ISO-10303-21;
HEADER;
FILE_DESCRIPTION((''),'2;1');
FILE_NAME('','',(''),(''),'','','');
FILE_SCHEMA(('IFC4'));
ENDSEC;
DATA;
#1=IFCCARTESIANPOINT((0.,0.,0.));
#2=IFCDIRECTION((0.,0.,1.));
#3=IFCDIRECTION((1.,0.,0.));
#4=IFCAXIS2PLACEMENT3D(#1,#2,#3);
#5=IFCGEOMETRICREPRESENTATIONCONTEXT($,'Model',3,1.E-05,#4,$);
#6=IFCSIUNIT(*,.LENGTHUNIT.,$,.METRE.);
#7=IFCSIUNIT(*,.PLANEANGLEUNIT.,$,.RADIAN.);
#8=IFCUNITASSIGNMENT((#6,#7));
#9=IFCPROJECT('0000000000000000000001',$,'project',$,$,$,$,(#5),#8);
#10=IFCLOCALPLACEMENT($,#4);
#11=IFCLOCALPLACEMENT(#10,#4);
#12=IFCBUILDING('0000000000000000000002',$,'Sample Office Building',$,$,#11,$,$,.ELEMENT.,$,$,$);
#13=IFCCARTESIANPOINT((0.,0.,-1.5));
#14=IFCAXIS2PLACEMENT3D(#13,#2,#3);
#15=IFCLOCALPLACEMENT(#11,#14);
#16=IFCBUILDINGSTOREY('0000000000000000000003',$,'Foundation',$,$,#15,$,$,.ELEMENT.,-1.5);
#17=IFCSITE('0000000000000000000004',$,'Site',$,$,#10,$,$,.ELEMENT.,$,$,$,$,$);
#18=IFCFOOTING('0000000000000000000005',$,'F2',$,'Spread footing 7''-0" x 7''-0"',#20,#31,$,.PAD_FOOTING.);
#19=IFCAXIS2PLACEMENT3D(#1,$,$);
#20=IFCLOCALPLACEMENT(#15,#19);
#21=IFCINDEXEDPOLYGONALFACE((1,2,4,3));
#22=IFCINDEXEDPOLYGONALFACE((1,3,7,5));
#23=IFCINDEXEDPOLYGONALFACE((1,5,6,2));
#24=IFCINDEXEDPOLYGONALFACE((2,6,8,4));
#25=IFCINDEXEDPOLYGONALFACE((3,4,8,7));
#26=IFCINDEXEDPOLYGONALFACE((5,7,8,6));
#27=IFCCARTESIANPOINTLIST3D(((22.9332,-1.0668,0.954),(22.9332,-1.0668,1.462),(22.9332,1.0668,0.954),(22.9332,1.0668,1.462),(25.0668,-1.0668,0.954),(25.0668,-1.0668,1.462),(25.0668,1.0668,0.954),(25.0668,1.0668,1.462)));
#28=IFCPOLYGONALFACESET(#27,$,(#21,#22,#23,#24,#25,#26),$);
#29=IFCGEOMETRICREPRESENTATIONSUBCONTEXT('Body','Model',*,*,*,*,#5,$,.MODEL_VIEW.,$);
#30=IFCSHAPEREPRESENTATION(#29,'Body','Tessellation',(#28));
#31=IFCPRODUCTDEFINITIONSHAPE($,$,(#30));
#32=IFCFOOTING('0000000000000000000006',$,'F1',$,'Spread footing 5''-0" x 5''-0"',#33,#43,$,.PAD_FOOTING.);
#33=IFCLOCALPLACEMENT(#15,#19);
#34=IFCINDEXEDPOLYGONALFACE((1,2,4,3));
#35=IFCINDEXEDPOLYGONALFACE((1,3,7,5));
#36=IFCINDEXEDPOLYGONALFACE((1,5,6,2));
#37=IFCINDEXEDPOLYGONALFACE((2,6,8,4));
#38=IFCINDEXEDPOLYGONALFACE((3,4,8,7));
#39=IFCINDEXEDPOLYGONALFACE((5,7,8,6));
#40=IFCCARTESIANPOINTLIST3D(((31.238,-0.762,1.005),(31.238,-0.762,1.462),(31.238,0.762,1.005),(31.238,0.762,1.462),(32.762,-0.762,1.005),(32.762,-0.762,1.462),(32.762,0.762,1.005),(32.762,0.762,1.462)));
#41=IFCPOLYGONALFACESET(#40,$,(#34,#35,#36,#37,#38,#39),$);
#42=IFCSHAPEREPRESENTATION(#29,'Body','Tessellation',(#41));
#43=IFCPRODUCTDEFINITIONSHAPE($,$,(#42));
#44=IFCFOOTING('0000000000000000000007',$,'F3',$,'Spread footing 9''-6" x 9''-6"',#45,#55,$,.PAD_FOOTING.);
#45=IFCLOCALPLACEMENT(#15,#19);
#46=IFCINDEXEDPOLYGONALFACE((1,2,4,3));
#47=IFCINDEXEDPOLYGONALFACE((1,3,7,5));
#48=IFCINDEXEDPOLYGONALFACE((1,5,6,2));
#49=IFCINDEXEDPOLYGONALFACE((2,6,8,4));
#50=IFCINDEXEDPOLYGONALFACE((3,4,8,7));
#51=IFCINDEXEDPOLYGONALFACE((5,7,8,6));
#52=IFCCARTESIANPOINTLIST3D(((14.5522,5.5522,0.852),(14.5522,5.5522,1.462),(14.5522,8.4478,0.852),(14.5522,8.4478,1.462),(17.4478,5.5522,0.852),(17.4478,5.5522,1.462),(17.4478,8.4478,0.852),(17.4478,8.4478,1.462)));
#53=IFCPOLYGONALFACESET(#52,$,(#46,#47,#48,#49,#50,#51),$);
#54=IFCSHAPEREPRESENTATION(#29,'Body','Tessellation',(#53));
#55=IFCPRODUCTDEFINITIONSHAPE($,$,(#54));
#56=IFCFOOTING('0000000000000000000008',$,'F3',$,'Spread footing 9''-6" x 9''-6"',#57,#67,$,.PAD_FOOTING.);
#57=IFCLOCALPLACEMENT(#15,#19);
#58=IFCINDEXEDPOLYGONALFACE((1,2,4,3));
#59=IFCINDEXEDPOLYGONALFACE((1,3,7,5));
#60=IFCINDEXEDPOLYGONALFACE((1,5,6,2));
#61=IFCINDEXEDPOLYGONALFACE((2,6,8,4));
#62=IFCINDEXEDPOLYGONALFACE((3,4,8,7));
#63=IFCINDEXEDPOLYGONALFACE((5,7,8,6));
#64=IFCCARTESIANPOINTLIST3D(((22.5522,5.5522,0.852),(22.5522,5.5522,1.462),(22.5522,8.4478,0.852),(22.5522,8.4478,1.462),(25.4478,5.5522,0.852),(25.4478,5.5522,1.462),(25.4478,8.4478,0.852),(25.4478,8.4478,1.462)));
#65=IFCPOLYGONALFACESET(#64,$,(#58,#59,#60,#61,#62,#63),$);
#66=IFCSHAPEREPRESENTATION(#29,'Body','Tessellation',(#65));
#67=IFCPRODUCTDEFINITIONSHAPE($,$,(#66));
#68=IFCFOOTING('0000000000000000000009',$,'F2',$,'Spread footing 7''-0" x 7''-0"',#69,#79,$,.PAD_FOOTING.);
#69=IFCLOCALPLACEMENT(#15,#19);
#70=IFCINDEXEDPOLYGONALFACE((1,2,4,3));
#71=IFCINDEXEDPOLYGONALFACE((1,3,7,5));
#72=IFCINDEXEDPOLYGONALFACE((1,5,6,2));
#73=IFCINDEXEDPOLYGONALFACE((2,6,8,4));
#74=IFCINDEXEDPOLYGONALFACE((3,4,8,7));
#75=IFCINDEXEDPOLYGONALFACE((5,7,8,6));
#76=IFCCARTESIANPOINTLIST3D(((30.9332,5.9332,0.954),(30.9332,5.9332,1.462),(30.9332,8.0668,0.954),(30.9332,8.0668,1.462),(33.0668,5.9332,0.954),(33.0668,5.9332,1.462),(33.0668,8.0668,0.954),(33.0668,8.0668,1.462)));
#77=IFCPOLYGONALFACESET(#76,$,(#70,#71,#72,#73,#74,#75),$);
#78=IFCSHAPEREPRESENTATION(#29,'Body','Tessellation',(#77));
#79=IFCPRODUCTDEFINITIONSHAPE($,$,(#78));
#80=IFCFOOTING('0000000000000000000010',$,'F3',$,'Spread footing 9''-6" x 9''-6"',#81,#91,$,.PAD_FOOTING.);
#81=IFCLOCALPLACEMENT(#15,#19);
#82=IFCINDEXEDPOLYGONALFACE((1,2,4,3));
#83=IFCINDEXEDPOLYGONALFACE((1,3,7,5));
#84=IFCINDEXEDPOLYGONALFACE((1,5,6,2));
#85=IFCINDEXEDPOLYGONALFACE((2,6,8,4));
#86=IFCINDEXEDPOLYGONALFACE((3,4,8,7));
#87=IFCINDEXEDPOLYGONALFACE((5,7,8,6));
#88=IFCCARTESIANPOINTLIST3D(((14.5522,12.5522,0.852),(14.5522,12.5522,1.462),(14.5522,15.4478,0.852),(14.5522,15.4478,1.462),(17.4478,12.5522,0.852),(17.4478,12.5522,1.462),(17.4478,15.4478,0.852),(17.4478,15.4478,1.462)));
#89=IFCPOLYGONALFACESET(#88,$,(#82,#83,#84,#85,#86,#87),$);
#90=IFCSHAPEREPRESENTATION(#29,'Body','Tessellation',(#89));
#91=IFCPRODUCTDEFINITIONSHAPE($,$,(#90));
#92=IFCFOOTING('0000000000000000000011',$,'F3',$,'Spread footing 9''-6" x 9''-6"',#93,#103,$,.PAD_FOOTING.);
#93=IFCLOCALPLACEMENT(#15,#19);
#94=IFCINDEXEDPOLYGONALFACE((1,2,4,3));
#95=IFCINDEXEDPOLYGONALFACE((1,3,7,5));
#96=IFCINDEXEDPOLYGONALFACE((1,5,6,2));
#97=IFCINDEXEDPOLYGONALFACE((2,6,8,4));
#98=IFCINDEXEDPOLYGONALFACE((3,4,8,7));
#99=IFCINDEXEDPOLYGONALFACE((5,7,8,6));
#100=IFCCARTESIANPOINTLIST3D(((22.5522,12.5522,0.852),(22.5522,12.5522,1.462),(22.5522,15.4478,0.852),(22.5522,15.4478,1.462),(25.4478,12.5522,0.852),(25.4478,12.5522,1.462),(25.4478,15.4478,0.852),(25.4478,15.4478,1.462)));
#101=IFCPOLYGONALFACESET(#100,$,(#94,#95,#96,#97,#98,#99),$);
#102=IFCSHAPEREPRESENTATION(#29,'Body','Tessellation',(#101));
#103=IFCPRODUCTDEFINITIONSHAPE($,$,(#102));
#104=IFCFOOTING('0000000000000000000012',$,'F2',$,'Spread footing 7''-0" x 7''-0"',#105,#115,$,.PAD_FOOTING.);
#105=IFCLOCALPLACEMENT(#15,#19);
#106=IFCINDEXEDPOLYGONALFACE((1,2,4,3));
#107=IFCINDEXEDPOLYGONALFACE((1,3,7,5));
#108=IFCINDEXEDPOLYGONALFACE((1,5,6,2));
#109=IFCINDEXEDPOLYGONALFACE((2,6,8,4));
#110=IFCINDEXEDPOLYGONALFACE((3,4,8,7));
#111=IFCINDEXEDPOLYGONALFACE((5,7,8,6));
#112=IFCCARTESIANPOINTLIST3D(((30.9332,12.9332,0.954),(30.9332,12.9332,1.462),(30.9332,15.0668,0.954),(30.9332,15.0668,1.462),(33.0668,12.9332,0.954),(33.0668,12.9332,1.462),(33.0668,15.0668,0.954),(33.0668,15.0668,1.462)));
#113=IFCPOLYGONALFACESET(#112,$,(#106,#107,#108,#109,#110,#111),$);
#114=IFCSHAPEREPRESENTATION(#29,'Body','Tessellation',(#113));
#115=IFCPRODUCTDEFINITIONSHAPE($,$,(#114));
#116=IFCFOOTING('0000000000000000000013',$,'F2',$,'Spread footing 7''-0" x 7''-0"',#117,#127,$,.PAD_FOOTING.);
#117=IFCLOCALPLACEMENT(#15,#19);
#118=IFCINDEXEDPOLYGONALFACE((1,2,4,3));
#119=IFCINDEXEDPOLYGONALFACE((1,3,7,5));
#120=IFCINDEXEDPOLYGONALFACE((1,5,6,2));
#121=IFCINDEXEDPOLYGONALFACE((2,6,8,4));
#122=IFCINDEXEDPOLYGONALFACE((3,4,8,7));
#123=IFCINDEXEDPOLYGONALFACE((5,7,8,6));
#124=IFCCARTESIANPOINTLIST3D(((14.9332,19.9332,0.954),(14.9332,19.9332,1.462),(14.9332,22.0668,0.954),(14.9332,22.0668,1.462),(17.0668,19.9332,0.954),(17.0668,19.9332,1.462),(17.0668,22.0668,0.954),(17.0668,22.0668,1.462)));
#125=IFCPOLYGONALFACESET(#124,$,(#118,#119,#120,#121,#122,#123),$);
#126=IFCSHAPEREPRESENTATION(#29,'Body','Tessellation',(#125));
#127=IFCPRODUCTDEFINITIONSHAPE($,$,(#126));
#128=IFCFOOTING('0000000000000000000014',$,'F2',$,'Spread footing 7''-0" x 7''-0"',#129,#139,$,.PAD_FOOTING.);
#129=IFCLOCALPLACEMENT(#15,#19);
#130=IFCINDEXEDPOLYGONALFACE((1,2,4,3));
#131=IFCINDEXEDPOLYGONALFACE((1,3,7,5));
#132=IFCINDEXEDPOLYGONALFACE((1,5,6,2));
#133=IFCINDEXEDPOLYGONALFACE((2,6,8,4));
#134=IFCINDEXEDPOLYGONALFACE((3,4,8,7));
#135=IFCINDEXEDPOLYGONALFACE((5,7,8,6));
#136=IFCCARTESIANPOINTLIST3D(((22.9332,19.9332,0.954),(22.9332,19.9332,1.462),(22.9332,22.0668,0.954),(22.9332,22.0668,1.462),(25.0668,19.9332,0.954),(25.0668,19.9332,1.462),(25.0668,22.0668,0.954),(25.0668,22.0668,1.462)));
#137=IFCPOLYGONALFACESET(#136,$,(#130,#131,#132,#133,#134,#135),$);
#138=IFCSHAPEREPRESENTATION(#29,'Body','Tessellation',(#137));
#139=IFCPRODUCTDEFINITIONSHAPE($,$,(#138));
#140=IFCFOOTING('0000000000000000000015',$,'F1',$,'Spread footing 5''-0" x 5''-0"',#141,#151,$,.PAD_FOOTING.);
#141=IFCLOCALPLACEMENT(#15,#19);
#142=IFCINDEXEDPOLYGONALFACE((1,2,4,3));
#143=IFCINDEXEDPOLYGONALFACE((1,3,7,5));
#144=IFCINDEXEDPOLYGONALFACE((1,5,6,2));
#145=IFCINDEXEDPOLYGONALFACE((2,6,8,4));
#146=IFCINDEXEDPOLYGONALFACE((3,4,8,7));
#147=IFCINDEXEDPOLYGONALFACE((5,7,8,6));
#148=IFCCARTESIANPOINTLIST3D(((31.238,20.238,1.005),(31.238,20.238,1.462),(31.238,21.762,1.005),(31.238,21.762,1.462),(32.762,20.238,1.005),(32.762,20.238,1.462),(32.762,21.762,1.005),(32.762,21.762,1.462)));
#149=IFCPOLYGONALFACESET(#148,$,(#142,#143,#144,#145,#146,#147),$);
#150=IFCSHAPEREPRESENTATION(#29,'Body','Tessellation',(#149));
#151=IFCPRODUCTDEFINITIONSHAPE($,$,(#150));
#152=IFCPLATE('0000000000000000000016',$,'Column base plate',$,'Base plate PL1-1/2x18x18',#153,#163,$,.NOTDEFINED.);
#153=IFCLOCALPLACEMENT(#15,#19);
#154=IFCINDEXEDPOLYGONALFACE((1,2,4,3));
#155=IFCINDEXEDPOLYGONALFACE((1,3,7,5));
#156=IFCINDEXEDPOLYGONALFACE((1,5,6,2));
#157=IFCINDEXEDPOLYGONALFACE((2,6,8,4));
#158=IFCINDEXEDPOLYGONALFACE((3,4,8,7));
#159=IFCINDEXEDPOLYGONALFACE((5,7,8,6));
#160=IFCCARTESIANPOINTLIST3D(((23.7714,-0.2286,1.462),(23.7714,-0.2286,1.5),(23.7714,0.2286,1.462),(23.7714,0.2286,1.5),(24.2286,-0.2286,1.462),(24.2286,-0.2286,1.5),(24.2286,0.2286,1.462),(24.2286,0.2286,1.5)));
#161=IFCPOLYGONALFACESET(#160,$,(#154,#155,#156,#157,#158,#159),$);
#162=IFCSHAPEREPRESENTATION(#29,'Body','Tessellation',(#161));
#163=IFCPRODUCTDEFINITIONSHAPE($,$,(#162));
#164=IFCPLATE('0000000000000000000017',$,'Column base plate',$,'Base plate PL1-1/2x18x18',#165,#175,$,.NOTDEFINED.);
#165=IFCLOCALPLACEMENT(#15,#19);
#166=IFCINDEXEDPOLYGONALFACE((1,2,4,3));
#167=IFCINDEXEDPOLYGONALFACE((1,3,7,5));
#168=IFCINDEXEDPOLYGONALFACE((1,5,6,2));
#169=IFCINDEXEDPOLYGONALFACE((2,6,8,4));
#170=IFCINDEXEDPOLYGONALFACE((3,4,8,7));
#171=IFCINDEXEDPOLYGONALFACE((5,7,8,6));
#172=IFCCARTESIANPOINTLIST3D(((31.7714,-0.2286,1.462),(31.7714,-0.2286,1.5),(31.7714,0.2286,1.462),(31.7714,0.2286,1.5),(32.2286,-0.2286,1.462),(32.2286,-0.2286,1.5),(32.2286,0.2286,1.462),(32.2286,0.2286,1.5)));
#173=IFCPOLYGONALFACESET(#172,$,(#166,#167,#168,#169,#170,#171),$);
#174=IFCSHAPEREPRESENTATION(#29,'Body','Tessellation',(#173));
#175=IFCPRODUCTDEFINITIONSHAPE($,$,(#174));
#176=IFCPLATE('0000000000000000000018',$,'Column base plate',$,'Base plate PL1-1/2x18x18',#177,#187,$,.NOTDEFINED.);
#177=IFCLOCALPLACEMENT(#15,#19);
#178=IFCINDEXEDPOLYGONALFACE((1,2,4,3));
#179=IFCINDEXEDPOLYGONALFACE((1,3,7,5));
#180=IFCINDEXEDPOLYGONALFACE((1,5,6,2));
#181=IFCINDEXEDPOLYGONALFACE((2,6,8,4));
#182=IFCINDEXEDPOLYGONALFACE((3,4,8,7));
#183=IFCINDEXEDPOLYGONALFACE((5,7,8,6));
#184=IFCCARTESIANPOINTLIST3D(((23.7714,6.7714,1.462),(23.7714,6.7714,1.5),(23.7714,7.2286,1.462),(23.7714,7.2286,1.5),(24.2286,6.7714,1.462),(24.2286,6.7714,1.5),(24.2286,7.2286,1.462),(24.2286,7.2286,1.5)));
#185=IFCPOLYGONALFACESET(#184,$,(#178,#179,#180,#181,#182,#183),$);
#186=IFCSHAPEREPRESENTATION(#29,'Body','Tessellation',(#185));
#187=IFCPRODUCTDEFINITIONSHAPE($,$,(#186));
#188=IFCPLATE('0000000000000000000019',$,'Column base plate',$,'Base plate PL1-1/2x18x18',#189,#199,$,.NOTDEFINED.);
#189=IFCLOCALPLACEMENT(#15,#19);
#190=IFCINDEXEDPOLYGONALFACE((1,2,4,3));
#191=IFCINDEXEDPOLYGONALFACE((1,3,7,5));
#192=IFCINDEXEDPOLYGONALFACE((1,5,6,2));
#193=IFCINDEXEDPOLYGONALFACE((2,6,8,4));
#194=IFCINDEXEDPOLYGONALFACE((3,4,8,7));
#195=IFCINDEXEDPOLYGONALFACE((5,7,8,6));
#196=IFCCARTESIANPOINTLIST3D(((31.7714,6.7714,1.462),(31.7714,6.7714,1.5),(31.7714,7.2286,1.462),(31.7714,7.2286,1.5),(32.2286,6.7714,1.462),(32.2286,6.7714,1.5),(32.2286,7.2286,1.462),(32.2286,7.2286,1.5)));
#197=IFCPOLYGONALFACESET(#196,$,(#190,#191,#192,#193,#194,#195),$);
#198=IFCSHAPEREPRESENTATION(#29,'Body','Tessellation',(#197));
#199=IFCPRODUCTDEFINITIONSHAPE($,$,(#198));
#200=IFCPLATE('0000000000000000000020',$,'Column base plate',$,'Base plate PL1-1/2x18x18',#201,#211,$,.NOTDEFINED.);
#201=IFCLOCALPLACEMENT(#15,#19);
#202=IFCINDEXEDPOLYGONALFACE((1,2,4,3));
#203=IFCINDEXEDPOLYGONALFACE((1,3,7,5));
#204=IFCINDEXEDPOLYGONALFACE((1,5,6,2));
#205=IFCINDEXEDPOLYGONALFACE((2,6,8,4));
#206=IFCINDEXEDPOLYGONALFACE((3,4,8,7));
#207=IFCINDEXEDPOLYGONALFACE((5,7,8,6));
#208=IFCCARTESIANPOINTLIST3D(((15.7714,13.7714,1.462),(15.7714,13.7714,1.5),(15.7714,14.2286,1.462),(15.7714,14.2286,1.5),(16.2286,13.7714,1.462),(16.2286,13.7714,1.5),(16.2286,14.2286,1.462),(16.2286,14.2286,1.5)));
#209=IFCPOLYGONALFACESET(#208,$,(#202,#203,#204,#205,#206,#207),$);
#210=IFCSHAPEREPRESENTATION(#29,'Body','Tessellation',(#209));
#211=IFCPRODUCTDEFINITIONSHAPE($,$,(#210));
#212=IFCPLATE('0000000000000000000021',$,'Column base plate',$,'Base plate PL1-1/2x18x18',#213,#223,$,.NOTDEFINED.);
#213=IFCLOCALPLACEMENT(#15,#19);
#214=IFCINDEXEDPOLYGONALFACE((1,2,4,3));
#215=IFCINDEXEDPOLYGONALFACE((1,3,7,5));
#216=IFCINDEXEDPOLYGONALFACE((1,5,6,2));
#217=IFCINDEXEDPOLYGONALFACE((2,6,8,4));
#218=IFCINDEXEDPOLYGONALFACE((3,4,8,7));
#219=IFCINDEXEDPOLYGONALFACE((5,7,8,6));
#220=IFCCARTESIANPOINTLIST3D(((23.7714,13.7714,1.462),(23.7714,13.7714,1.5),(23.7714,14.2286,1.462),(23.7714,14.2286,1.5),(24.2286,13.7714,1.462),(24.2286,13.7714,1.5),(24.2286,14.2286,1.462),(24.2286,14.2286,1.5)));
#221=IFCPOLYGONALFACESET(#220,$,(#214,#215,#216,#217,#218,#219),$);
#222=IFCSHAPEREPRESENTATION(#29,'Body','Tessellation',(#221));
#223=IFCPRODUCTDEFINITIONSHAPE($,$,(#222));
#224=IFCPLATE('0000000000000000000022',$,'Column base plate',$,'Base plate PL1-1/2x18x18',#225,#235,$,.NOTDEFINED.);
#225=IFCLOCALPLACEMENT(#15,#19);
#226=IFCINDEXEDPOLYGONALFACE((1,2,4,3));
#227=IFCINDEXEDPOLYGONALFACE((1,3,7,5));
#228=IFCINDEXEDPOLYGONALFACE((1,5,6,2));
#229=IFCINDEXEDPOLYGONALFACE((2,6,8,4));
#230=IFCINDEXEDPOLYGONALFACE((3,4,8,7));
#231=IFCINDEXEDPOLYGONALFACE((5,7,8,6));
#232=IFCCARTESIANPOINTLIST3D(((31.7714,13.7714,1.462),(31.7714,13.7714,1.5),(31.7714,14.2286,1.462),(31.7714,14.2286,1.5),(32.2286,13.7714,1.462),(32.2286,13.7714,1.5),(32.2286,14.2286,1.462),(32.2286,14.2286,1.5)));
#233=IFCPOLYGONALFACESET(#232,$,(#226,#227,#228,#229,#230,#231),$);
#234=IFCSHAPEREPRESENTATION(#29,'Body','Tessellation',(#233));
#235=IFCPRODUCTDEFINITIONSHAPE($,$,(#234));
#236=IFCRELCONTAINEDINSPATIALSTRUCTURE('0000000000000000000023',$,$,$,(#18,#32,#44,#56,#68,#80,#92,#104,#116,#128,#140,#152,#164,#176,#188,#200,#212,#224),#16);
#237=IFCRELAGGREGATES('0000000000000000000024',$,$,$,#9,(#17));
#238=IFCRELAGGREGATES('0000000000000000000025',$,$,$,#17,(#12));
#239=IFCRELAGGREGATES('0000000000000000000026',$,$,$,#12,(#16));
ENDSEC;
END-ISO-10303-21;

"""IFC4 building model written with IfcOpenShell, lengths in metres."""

from ifc_helpers import new_model, si_unit, frame, origin_with_axes, place, context, subcontext, project, spatial, rectangle, extrude, element, save


model = new_model("IFC4")

# Units and contexts
model_context = context("Model", 3, precision=1e-05, world=origin_with_axes())
body_context = subcontext(model_context, "Body", "Model", "MODEL_VIEW")
ifc_project = project(units=[si_unit("LENGTHUNIT", "METRE"), si_unit("PLANEANGLEUNIT", "RADIAN")], contexts=[model_context])

# Site, building, storey
site_placement = place(None, origin_with_axes())
site = spatial("IfcSite", under=ifc_project, at=site_placement, Name="Site", CompositionType="ELEMENT")
building_placement = place(site_placement, origin_with_axes())
building = spatial("IfcBuilding", under=site, at=building_placement, Name="Sample Office Building", CompositionType="ELEMENT")
storey_placement = place(building_placement, frame((0.0, 0.0, -1.5), z_axis=(0.0, 0.0, 1.0), x_axis=(1.0, 0.0, 0.0)))
storey = spatial("IfcBuildingStorey", under=building, at=storey_placement, Name="Foundation", CompositionType="ELEMENT", Elevation=-1.5)

# Footings
footing_1_placement = place(None, frame((24.0, 0.0, -0.546), z_axis=(0.0, 0.0, 1.0), x_axis=(1.0, 0.0, 0.0)))
element("IfcFooting", 1, at=footing_1_placement, inside=storey, Name="F2", ObjectType="Spread footing 7'-0\" x 7'-0\"", PredefinedType="PAD_FOOTING", context=body_context, shape_type="SweptSolid", body=[
    extrude(rectangle(XDim=2.1336, YDim=2.1336), None, (0.0, 0.0, 1.0), 0.508),
])
footing_2_placement = place(None, frame((32.0, 0.0, -0.495), z_axis=(0.0, 0.0, 1.0), x_axis=(1.0, 0.0, 0.0)))
element("IfcFooting", 2, at=footing_2_placement, inside=storey, Name="F1", ObjectType="Spread footing 5'-0\" x 5'-0\"", PredefinedType="PAD_FOOTING", context=body_context, shape_type="SweptSolid", body=[
    extrude(rectangle(XDim=1.524, YDim=1.524), None, (0.0, 0.0, 1.0), 0.457),
])
for number, where, z_axis, x_axis, name in (
    (3, (16.0, 7.0, -0.648), (0.0, 0.0, 1.0), (1.0, 0.0, 0.0), "F3"),
    (4, (24.0, 7.0, -0.648), (0.0, 0.0, 1.0), (1.0, 0.0, 0.0), "F3"),
):
    element("IfcFooting", number, at=place(None, frame(where, z_axis=z_axis, x_axis=x_axis)), inside=storey, Name=name, ObjectType="Spread footing 9'-6\" x 9'-6\"", PredefinedType="PAD_FOOTING", context=body_context, shape_type="SweptSolid", body=[
        extrude(rectangle(XDim=2.8956, YDim=2.8956), None, (0.0, 0.0, 1.0), 0.61),
    ])
footing_3_placement = place(None, frame((32.0, 7.0, -0.546), z_axis=(0.0, 0.0, 1.0), x_axis=(1.0, 0.0, 0.0)))
element("IfcFooting", 5, at=footing_3_placement, inside=storey, Name="F2", ObjectType="Spread footing 7'-0\" x 7'-0\"", PredefinedType="PAD_FOOTING", context=body_context, shape_type="SweptSolid", body=[
    extrude(rectangle(XDim=2.1336, YDim=2.1336), None, (0.0, 0.0, 1.0), 0.508),
])
for number, where, z_axis, x_axis, name in (
    (6, (16.0, 14.0, -0.648), (0.0, 0.0, 1.0), (1.0, 0.0, 0.0), "F3"),
    (7, (24.0, 14.0, -0.648), (0.0, 0.0, 1.0), (1.0, 0.0, 0.0), "F3"),
):
    element("IfcFooting", number, at=place(None, frame(where, z_axis=z_axis, x_axis=x_axis)), inside=storey, Name=name, ObjectType="Spread footing 9'-6\" x 9'-6\"", PredefinedType="PAD_FOOTING", context=body_context, shape_type="SweptSolid", body=[
        extrude(rectangle(XDim=2.8956, YDim=2.8956), None, (0.0, 0.0, 1.0), 0.61),
    ])
for number, where, z_axis, x_axis, name in (
    (8, (32.0, 14.0, -0.546), (0.0, 0.0, 1.0), (1.0, 0.0, 0.0), "F2"),
    (9, (16.0, 21.0, -0.546), (0.0, 0.0, 1.0), (1.0, 0.0, 0.0), "F2"),
    (10, (24.0, 21.0, -0.546), (0.0, 0.0, 1.0), (1.0, 0.0, 0.0), "F2"),
):
    element("IfcFooting", number, at=place(None, frame(where, z_axis=z_axis, x_axis=x_axis)), inside=storey, Name=name, ObjectType="Spread footing 7'-0\" x 7'-0\"", PredefinedType="PAD_FOOTING", context=body_context, shape_type="SweptSolid", body=[
        extrude(rectangle(XDim=2.1336, YDim=2.1336), None, (0.0, 0.0, 1.0), 0.508),
    ])
footing_4_placement = place(None, frame((32.0, 21.0, -0.495), z_axis=(0.0, 0.0, 1.0), x_axis=(1.0, 0.0, 0.0)))
element("IfcFooting", 11, at=footing_4_placement, inside=storey, Name="F1", ObjectType="Spread footing 5'-0\" x 5'-0\"", PredefinedType="PAD_FOOTING", context=body_context, shape_type="SweptSolid", body=[
    extrude(rectangle(XDim=1.524, YDim=1.524), None, (0.0, 0.0, 1.0), 0.457),
])

# Plates
for number, where, z_axis, x_axis, name in (
    (12, (24.0, 0.0, -0.038), (0.0, 0.0, 1.0), (1.0, 0.0, 0.0), "Column base plate"),
    (13, (32.0, 0.0, -0.038), (0.0, 0.0, 1.0), (1.0, 0.0, 0.0), "Column base plate"),
):
    element("IfcPlate", number, at=place(None, frame(where, z_axis=z_axis, x_axis=x_axis)), inside=storey, Name=name, ObjectType="Base plate PL1-1/2x18x18", PredefinedType="NOTDEFINED", context=body_context, shape_type="SweptSolid", body=[
        extrude(rectangle(XDim=0.4572, YDim=0.4572), None, (0.0, 0.0, 1.0), 0.038),
    ])
for number, where, z_axis, x_axis, name in (
    (14, (24.0, 7.0, -0.038), (0.0, 0.0, 1.0), (1.0, 0.0, 0.0), "Column base plate"),
    (15, (32.0, 7.0, -0.038), (0.0, 0.0, 1.0), (1.0, 0.0, 0.0), "Column base plate"),
    (16, (16.0, 14.0, -0.038), (0.0, 0.0, 1.0), (1.0, 0.0, 0.0), "Column base plate"),
    (17, (24.0, 14.0, -0.038), (0.0, 0.0, 1.0), (1.0, 0.0, 0.0), "Column base plate"),
    (18, (32.0, 14.0, -0.038), (0.0, 0.0, 1.0), (1.0, 0.0, 0.0), "Column base plate"),
):
    element("IfcPlate", number, at=place(None, frame(where, z_axis=z_axis, x_axis=x_axis)), inside=storey, Name=name, ObjectType="Base plate PL1-1/2x18x18", PredefinedType="NOTDEFINED", context=body_context, shape_type="SweptSolid", body=[
        extrude(rectangle(XDim=0.4572, YDim=0.4572), None, (0.0, 0.0, 1.0), 0.038),
    ])

save(model, "model.ifc")
